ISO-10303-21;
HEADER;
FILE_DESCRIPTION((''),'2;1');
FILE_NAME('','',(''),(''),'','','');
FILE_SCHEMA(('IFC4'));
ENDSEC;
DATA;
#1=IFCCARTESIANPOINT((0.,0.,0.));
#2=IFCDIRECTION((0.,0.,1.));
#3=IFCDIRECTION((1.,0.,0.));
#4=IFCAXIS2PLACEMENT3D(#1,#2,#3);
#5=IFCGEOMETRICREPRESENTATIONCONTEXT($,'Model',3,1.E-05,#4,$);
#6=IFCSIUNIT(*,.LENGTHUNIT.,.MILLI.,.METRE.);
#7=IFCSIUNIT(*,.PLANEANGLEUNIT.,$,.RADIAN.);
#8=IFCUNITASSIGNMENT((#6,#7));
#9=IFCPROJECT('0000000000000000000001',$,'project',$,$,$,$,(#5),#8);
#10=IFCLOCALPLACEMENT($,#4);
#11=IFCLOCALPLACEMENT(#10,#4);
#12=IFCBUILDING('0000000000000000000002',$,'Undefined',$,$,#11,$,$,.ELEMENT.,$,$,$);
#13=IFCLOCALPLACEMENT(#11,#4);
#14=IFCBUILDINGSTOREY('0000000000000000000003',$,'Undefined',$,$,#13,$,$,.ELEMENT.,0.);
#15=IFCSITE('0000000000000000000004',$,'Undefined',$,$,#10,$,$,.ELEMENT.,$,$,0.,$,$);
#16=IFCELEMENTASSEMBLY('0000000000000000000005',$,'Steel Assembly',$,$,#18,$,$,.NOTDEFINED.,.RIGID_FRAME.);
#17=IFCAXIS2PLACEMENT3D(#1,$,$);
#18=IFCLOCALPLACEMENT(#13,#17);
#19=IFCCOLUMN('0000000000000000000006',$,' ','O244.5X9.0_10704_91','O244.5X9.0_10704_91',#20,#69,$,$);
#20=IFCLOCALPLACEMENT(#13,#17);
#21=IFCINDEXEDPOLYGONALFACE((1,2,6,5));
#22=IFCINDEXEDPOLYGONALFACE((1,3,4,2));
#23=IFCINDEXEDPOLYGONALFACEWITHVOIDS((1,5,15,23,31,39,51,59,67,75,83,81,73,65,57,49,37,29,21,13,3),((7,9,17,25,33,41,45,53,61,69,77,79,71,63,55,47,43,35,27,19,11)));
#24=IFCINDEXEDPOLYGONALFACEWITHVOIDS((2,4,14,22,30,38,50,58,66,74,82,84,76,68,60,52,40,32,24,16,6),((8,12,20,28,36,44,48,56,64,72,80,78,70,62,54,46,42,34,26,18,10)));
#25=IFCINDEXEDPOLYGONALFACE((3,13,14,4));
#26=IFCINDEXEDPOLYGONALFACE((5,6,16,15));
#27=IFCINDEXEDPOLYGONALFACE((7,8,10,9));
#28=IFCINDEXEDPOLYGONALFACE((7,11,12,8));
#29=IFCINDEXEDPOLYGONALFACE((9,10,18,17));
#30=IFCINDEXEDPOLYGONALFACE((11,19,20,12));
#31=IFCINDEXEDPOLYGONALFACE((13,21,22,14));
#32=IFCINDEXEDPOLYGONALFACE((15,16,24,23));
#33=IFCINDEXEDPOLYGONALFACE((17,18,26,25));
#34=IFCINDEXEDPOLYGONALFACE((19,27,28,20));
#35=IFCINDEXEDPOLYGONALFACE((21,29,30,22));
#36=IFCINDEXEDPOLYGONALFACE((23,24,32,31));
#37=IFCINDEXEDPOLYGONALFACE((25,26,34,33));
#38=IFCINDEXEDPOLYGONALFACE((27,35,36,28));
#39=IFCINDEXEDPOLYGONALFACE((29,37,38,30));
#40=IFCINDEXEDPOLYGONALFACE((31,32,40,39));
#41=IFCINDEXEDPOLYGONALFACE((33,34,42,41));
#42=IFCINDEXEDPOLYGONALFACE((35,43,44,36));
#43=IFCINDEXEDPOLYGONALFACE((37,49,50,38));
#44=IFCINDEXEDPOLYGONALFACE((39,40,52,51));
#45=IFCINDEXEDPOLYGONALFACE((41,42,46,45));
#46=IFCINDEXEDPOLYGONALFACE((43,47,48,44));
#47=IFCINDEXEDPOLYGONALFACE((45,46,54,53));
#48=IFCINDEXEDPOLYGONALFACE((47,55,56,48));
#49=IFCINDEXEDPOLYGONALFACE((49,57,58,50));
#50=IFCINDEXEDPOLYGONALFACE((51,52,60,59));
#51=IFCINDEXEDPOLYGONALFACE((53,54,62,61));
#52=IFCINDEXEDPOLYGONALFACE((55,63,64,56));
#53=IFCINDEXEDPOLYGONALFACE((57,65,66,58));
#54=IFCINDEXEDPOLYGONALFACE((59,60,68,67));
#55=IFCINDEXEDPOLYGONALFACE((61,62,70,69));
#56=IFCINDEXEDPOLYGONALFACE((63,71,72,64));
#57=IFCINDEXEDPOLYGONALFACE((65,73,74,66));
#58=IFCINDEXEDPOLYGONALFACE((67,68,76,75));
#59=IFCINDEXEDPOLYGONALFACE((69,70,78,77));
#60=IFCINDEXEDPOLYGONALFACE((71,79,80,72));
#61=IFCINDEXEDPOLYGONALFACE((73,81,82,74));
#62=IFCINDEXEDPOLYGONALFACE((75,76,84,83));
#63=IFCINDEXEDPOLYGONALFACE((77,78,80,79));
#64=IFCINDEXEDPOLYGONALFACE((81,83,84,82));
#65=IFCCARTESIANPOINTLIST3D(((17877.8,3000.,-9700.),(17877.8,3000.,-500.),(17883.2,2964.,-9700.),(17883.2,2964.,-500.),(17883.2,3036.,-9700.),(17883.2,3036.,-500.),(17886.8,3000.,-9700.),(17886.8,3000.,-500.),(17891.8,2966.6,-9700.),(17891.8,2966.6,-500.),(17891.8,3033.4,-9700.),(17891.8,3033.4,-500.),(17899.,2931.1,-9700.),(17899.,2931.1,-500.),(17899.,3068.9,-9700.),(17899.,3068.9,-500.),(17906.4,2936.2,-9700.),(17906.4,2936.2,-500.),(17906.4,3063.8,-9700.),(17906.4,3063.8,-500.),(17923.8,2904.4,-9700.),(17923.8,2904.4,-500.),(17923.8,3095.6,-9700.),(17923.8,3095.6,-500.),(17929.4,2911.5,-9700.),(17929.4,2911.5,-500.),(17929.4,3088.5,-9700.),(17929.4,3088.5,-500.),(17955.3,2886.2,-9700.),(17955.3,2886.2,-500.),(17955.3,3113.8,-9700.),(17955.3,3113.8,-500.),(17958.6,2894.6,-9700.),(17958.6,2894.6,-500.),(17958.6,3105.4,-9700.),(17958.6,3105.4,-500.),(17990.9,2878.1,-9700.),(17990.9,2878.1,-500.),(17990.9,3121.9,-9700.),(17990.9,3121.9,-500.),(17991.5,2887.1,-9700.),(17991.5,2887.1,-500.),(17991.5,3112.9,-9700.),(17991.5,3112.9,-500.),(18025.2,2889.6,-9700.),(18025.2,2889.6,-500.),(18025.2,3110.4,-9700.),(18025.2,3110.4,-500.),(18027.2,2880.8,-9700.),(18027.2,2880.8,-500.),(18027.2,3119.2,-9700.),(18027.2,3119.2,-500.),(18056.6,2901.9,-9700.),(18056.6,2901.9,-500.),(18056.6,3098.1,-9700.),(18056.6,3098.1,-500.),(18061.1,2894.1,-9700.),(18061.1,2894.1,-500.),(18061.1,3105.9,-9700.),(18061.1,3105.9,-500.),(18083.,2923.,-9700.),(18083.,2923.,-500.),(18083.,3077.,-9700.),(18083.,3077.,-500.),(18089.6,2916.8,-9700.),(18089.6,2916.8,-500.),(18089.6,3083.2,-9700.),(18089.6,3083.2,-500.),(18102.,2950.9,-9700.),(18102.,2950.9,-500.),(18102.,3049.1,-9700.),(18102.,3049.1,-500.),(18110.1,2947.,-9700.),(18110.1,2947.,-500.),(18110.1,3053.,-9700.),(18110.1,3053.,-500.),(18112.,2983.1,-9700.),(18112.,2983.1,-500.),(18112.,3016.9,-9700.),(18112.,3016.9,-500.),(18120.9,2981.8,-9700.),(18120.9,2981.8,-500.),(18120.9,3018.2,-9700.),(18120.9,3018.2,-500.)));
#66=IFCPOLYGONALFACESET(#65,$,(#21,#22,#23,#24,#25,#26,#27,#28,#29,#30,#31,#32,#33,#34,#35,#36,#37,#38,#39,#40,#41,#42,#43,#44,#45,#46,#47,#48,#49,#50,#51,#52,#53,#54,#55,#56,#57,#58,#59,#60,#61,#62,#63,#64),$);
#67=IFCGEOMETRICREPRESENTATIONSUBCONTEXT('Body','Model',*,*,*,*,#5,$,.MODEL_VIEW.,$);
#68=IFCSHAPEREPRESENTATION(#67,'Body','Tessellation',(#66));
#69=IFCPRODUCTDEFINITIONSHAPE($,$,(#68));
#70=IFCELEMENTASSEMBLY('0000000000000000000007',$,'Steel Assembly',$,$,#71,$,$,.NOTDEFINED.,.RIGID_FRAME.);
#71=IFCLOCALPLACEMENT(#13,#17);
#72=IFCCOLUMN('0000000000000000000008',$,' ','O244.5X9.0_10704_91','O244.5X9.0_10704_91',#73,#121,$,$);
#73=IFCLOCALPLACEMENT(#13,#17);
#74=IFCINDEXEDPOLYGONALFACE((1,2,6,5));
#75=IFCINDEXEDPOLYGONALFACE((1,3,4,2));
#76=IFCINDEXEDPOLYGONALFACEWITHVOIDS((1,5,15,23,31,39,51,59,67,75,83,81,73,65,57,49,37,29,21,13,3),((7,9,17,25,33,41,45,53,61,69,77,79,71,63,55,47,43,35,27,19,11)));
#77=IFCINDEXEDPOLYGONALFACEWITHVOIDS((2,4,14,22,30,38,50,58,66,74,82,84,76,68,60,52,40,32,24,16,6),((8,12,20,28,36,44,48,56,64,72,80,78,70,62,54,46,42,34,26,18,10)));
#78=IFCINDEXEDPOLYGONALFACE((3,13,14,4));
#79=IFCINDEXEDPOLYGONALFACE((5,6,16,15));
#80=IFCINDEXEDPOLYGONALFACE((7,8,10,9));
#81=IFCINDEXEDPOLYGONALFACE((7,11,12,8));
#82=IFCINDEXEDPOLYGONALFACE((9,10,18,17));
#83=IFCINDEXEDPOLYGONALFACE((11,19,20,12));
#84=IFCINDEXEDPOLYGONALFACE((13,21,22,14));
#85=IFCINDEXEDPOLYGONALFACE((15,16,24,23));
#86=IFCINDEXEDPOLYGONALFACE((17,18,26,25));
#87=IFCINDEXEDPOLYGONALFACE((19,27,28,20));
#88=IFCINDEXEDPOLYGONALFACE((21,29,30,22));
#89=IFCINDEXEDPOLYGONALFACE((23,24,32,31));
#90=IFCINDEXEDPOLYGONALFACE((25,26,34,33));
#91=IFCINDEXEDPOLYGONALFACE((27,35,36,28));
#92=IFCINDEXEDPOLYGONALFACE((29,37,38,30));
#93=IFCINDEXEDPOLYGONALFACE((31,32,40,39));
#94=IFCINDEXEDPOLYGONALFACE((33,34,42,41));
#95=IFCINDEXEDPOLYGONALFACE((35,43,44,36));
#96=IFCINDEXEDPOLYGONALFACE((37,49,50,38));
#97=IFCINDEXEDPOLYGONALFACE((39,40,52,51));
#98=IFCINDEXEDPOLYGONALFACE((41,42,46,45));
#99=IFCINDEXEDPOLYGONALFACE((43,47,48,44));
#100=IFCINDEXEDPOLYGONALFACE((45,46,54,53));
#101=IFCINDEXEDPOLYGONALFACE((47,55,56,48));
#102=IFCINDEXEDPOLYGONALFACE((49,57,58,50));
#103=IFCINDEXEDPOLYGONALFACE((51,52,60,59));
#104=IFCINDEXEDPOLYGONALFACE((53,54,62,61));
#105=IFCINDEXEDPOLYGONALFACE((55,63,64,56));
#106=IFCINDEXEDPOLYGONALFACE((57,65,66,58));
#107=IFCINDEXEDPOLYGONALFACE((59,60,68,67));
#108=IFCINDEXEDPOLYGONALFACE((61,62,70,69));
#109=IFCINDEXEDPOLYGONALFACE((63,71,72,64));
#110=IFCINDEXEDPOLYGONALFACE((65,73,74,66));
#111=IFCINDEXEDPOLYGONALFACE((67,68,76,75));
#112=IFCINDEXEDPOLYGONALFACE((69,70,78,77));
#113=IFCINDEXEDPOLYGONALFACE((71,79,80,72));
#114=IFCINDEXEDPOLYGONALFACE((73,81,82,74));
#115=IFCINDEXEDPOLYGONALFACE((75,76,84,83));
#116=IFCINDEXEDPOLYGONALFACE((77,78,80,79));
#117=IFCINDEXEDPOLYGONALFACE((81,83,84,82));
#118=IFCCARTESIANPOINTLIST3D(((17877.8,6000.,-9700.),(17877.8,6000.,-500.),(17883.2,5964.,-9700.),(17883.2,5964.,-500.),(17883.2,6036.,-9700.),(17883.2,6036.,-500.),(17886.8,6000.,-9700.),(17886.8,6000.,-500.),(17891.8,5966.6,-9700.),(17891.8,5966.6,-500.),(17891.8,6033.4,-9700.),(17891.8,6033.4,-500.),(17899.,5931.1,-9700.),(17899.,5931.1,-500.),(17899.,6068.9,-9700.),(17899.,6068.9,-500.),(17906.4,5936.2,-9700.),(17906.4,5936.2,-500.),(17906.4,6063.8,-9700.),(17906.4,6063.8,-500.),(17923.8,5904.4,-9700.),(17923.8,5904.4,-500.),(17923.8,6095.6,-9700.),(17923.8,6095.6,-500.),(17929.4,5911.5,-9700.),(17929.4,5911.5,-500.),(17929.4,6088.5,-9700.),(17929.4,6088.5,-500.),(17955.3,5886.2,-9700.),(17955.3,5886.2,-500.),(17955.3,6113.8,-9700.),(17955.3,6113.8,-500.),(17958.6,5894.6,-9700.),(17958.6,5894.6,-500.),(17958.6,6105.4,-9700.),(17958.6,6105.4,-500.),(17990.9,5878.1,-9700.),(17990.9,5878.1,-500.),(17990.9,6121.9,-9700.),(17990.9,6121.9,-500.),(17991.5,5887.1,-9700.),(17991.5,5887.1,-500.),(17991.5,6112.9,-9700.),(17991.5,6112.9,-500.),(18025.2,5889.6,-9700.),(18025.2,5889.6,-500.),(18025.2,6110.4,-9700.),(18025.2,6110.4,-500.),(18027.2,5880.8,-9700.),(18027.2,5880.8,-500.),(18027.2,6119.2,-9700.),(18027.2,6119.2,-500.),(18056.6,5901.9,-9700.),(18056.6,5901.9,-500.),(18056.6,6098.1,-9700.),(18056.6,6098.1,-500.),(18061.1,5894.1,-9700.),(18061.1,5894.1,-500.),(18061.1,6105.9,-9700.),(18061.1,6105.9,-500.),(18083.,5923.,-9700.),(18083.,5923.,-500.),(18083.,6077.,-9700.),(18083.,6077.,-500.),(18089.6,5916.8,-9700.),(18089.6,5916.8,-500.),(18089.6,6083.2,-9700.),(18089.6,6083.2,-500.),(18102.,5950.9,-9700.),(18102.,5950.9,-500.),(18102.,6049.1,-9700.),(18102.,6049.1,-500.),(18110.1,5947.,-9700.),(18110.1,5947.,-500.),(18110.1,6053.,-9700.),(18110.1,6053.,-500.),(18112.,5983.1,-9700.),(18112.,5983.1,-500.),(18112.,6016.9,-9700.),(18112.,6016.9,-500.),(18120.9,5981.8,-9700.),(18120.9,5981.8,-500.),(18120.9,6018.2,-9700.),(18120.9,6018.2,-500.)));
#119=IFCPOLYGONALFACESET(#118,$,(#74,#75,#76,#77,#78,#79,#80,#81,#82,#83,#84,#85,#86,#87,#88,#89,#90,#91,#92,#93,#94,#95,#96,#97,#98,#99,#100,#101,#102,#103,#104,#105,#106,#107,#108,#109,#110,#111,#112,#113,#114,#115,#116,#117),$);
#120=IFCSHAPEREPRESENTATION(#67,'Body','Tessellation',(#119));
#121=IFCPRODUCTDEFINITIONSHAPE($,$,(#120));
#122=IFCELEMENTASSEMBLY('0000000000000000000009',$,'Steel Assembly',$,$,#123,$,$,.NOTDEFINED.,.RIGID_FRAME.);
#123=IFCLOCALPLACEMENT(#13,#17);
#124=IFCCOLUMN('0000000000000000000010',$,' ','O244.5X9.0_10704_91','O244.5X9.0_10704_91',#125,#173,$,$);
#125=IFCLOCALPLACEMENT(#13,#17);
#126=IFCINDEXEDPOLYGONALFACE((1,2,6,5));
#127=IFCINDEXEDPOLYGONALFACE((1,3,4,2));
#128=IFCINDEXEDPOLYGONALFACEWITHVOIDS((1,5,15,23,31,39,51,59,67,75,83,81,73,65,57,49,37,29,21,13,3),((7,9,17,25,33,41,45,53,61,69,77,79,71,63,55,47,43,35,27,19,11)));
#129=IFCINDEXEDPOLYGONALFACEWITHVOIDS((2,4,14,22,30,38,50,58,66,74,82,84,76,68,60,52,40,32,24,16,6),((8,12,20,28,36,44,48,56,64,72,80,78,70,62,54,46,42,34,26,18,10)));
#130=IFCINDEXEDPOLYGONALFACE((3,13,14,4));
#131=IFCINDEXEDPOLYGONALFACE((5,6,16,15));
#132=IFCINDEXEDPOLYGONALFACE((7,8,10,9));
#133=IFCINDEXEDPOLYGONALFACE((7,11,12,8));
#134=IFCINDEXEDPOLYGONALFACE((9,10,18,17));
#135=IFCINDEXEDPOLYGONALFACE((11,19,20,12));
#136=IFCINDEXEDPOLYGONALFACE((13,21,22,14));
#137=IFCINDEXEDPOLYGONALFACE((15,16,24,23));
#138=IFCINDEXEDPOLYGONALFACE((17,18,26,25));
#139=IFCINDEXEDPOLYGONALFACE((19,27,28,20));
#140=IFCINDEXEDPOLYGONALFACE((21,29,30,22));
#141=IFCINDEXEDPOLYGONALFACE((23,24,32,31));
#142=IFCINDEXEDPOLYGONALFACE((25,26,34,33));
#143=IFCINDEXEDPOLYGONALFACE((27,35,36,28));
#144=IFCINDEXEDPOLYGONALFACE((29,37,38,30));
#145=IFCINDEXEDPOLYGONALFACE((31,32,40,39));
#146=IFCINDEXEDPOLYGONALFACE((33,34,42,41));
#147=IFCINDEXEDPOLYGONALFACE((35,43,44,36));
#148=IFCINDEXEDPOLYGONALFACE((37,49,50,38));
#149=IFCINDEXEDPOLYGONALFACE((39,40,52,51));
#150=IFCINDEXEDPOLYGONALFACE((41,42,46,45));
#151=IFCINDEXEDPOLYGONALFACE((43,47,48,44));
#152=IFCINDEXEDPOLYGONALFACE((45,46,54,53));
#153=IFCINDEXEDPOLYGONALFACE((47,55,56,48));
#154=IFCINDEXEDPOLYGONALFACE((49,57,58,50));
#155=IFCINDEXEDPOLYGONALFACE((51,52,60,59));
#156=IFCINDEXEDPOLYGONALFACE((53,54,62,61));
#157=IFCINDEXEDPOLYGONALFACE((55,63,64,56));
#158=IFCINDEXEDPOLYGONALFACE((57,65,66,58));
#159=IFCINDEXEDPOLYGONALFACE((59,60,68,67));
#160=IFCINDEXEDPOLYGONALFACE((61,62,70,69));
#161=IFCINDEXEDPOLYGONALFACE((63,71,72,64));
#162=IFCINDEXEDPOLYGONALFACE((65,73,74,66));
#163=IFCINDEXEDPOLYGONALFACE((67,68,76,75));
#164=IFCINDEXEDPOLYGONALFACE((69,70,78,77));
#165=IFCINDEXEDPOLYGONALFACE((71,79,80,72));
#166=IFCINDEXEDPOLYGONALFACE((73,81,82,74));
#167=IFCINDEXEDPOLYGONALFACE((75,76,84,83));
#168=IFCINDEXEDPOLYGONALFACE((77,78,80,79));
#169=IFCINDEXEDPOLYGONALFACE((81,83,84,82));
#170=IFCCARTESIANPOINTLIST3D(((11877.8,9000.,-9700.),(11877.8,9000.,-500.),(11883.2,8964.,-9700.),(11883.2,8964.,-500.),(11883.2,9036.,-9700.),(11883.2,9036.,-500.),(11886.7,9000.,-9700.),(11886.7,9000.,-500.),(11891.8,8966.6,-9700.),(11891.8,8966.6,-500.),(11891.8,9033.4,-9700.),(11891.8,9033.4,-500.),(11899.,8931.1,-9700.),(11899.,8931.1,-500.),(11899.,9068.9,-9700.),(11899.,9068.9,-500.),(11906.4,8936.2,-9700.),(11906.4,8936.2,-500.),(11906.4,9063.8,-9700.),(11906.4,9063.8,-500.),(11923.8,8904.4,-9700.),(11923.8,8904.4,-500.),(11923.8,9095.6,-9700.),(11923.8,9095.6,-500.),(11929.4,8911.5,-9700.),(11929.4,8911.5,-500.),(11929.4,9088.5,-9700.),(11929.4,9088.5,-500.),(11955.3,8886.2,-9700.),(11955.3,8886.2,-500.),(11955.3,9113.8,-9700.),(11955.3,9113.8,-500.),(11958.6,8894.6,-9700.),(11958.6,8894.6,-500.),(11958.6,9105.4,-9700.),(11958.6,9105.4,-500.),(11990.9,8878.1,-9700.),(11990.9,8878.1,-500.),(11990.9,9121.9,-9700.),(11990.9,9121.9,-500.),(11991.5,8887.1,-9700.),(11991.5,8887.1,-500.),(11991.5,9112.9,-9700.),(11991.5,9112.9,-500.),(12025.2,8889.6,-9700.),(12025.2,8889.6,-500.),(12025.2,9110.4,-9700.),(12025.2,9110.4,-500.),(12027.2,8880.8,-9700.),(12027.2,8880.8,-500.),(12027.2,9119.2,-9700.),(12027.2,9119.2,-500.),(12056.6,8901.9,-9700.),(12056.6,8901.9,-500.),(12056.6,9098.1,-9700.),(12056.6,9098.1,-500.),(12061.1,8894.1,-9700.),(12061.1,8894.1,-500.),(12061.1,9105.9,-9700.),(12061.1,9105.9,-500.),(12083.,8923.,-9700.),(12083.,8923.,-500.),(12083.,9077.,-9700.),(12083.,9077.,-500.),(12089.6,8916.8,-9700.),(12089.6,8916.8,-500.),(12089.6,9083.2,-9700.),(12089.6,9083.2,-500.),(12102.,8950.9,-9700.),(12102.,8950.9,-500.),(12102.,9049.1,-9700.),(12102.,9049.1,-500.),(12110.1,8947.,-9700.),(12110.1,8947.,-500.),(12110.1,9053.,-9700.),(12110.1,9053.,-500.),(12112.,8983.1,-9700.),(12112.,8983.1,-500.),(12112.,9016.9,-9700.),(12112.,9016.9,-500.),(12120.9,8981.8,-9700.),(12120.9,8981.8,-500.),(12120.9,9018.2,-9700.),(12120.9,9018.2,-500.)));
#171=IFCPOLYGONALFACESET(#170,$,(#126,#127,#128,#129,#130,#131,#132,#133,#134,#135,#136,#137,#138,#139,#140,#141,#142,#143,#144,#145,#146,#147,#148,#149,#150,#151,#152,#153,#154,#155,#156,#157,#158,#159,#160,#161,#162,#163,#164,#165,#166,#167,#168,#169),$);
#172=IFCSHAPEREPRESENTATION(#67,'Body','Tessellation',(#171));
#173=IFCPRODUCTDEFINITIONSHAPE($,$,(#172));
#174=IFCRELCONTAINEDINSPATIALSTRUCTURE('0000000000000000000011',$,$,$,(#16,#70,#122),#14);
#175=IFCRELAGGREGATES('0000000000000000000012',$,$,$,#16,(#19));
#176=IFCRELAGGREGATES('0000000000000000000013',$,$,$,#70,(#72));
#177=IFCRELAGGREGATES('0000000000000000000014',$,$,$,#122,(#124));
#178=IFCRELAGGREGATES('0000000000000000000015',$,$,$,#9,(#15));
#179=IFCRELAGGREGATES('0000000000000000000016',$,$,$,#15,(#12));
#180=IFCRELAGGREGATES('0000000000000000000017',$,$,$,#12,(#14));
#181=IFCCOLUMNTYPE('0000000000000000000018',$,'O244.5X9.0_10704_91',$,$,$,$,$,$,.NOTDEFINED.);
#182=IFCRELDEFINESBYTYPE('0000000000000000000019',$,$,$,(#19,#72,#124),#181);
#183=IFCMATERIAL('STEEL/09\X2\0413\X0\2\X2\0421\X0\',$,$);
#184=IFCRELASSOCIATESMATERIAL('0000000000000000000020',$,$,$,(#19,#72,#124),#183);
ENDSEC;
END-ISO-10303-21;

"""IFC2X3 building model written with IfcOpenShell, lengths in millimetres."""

from ifc_helpers import new_model, si_unit, frame, origin_with_axes, origin_2d_with_axis, place, context, subcontext, project, spatial, hollow_circle, extrude, material, type_object, element, aggregate, save


model = new_model("IFC2X3")

# Units and contexts
model_context = context("Model", 3, precision=1e-05, world=origin_with_axes())
body_context = subcontext(model_context, "Body", "Model", "MODEL_VIEW")
ifc_project = project(units=[si_unit("LENGTHUNIT", "METRE", prefix="MILLI"), si_unit("PLANEANGLEUNIT", "RADIAN")], contexts=[model_context])

# Site, building, storey
site_placement = place(None, origin_with_axes())
site = spatial("IfcSite", under=ifc_project, at=site_placement, Name="Undefined", CompositionType="ELEMENT", RefElevation=0.0)
building_placement = place(site_placement, origin_with_axes())
building = spatial("IfcBuilding", under=site, at=building_placement, Name="Undefined", CompositionType="ELEMENT")
storey_placement = place(building_placement, origin_with_axes())
storey = spatial("IfcBuildingStorey", under=building, at=storey_placement, Name="Undefined", CompositionType="ELEMENT", Elevation=0.0)

# Element assemblies, columns
ifc_material_1 = material(Name="STEEL/09Г2С")
column_type_1 = type_object("IfcColumnType", Name="O244.5X9.0_10704_91", PredefinedType="NOTDEFINED")
assembly_1_placement = place(storey_placement, origin_with_axes())
assembly_1 = element("IfcElementAssembly", 1, at=assembly_1_placement, inside=storey, Name="Steel Assembly", AssemblyPlace="NOTDEFINED", PredefinedType="RIGID_FRAME")
column_1_placement = place(assembly_1_placement, frame((18000.0, 3000.0, -9700.0), z_axis=(0.0, 0.0, 1.0), x_axis=(0.0, 1.0, 0.0)))
column_1 = element("IfcColumn", 2, at=column_1_placement, type_object=column_type_1, material=ifc_material_1, Name=" ", Description="O244.5X9.0_10704_91", ObjectType="O244.5X9.0_10704_91", context=body_context, shape_type="SweptSolid", body=[
    extrude(hollow_circle(Radius=122.2, WallThickness=9.0, at=origin_2d_with_axis()), frame((0.0, 0.0, 9200.0), z_axis=(0.0, 0.0, -1.0), x_axis=(0.0, 1.0, 0.0)), (0.0, 0.0, 1.0), 9200.0),
])
aggregate(assembly_1, [column_1])
assembly_2_placement = place(storey_placement, origin_with_axes())
assembly_2 = element("IfcElementAssembly", 3, at=assembly_2_placement, inside=storey, Name="Steel Assembly", AssemblyPlace="NOTDEFINED", PredefinedType="RIGID_FRAME")
column_2_placement = place(assembly_2_placement, frame((18000.0, 6000.0, -9700.0), z_axis=(0.0, 0.0, 1.0), x_axis=(0.0, 1.0, 0.0)))
column_2 = element("IfcColumn", 4, at=column_2_placement, type_object=column_type_1, material=ifc_material_1, Name=" ", Description="O244.5X9.0_10704_91", ObjectType="O244.5X9.0_10704_91", context=body_context, shape_type="SweptSolid", body=[
    extrude(hollow_circle(Radius=122.2, WallThickness=9.0, at=origin_2d_with_axis()), frame((0.0, 0.0, 9200.0), z_axis=(0.0, 0.0, -1.0), x_axis=(0.0, 1.0, 0.0)), (0.0, 0.0, 1.0), 9200.0),
])
aggregate(assembly_2, [column_2])
assembly_3_placement = place(storey_placement, origin_with_axes())
assembly_3 = element("IfcElementAssembly", 5, at=assembly_3_placement, inside=storey, Name="Steel Assembly", AssemblyPlace="NOTDEFINED", PredefinedType="RIGID_FRAME")
column_3_placement = place(assembly_3_placement, frame((12000.0, 9000.0, -9700.0), z_axis=(0.0, 0.0, 1.0), x_axis=(0.0, 1.0, 0.0)))
column_3 = element("IfcColumn", 6, at=column_3_placement, type_object=column_type_1, material=ifc_material_1, Name=" ", Description="O244.5X9.0_10704_91", ObjectType="O244.5X9.0_10704_91", context=body_context, shape_type="SweptSolid", body=[
    extrude(hollow_circle(Radius=122.2, WallThickness=9.0, at=origin_2d_with_axis()), frame((0.0, 0.0, 9200.0), z_axis=(0.0, 0.0, -1.0), x_axis=(0.0, 1.0, 0.0)), (0.0, 0.0, 1.0), 9200.0),
])
aggregate(assembly_3, [column_3])

save(model, "model.ifc")
